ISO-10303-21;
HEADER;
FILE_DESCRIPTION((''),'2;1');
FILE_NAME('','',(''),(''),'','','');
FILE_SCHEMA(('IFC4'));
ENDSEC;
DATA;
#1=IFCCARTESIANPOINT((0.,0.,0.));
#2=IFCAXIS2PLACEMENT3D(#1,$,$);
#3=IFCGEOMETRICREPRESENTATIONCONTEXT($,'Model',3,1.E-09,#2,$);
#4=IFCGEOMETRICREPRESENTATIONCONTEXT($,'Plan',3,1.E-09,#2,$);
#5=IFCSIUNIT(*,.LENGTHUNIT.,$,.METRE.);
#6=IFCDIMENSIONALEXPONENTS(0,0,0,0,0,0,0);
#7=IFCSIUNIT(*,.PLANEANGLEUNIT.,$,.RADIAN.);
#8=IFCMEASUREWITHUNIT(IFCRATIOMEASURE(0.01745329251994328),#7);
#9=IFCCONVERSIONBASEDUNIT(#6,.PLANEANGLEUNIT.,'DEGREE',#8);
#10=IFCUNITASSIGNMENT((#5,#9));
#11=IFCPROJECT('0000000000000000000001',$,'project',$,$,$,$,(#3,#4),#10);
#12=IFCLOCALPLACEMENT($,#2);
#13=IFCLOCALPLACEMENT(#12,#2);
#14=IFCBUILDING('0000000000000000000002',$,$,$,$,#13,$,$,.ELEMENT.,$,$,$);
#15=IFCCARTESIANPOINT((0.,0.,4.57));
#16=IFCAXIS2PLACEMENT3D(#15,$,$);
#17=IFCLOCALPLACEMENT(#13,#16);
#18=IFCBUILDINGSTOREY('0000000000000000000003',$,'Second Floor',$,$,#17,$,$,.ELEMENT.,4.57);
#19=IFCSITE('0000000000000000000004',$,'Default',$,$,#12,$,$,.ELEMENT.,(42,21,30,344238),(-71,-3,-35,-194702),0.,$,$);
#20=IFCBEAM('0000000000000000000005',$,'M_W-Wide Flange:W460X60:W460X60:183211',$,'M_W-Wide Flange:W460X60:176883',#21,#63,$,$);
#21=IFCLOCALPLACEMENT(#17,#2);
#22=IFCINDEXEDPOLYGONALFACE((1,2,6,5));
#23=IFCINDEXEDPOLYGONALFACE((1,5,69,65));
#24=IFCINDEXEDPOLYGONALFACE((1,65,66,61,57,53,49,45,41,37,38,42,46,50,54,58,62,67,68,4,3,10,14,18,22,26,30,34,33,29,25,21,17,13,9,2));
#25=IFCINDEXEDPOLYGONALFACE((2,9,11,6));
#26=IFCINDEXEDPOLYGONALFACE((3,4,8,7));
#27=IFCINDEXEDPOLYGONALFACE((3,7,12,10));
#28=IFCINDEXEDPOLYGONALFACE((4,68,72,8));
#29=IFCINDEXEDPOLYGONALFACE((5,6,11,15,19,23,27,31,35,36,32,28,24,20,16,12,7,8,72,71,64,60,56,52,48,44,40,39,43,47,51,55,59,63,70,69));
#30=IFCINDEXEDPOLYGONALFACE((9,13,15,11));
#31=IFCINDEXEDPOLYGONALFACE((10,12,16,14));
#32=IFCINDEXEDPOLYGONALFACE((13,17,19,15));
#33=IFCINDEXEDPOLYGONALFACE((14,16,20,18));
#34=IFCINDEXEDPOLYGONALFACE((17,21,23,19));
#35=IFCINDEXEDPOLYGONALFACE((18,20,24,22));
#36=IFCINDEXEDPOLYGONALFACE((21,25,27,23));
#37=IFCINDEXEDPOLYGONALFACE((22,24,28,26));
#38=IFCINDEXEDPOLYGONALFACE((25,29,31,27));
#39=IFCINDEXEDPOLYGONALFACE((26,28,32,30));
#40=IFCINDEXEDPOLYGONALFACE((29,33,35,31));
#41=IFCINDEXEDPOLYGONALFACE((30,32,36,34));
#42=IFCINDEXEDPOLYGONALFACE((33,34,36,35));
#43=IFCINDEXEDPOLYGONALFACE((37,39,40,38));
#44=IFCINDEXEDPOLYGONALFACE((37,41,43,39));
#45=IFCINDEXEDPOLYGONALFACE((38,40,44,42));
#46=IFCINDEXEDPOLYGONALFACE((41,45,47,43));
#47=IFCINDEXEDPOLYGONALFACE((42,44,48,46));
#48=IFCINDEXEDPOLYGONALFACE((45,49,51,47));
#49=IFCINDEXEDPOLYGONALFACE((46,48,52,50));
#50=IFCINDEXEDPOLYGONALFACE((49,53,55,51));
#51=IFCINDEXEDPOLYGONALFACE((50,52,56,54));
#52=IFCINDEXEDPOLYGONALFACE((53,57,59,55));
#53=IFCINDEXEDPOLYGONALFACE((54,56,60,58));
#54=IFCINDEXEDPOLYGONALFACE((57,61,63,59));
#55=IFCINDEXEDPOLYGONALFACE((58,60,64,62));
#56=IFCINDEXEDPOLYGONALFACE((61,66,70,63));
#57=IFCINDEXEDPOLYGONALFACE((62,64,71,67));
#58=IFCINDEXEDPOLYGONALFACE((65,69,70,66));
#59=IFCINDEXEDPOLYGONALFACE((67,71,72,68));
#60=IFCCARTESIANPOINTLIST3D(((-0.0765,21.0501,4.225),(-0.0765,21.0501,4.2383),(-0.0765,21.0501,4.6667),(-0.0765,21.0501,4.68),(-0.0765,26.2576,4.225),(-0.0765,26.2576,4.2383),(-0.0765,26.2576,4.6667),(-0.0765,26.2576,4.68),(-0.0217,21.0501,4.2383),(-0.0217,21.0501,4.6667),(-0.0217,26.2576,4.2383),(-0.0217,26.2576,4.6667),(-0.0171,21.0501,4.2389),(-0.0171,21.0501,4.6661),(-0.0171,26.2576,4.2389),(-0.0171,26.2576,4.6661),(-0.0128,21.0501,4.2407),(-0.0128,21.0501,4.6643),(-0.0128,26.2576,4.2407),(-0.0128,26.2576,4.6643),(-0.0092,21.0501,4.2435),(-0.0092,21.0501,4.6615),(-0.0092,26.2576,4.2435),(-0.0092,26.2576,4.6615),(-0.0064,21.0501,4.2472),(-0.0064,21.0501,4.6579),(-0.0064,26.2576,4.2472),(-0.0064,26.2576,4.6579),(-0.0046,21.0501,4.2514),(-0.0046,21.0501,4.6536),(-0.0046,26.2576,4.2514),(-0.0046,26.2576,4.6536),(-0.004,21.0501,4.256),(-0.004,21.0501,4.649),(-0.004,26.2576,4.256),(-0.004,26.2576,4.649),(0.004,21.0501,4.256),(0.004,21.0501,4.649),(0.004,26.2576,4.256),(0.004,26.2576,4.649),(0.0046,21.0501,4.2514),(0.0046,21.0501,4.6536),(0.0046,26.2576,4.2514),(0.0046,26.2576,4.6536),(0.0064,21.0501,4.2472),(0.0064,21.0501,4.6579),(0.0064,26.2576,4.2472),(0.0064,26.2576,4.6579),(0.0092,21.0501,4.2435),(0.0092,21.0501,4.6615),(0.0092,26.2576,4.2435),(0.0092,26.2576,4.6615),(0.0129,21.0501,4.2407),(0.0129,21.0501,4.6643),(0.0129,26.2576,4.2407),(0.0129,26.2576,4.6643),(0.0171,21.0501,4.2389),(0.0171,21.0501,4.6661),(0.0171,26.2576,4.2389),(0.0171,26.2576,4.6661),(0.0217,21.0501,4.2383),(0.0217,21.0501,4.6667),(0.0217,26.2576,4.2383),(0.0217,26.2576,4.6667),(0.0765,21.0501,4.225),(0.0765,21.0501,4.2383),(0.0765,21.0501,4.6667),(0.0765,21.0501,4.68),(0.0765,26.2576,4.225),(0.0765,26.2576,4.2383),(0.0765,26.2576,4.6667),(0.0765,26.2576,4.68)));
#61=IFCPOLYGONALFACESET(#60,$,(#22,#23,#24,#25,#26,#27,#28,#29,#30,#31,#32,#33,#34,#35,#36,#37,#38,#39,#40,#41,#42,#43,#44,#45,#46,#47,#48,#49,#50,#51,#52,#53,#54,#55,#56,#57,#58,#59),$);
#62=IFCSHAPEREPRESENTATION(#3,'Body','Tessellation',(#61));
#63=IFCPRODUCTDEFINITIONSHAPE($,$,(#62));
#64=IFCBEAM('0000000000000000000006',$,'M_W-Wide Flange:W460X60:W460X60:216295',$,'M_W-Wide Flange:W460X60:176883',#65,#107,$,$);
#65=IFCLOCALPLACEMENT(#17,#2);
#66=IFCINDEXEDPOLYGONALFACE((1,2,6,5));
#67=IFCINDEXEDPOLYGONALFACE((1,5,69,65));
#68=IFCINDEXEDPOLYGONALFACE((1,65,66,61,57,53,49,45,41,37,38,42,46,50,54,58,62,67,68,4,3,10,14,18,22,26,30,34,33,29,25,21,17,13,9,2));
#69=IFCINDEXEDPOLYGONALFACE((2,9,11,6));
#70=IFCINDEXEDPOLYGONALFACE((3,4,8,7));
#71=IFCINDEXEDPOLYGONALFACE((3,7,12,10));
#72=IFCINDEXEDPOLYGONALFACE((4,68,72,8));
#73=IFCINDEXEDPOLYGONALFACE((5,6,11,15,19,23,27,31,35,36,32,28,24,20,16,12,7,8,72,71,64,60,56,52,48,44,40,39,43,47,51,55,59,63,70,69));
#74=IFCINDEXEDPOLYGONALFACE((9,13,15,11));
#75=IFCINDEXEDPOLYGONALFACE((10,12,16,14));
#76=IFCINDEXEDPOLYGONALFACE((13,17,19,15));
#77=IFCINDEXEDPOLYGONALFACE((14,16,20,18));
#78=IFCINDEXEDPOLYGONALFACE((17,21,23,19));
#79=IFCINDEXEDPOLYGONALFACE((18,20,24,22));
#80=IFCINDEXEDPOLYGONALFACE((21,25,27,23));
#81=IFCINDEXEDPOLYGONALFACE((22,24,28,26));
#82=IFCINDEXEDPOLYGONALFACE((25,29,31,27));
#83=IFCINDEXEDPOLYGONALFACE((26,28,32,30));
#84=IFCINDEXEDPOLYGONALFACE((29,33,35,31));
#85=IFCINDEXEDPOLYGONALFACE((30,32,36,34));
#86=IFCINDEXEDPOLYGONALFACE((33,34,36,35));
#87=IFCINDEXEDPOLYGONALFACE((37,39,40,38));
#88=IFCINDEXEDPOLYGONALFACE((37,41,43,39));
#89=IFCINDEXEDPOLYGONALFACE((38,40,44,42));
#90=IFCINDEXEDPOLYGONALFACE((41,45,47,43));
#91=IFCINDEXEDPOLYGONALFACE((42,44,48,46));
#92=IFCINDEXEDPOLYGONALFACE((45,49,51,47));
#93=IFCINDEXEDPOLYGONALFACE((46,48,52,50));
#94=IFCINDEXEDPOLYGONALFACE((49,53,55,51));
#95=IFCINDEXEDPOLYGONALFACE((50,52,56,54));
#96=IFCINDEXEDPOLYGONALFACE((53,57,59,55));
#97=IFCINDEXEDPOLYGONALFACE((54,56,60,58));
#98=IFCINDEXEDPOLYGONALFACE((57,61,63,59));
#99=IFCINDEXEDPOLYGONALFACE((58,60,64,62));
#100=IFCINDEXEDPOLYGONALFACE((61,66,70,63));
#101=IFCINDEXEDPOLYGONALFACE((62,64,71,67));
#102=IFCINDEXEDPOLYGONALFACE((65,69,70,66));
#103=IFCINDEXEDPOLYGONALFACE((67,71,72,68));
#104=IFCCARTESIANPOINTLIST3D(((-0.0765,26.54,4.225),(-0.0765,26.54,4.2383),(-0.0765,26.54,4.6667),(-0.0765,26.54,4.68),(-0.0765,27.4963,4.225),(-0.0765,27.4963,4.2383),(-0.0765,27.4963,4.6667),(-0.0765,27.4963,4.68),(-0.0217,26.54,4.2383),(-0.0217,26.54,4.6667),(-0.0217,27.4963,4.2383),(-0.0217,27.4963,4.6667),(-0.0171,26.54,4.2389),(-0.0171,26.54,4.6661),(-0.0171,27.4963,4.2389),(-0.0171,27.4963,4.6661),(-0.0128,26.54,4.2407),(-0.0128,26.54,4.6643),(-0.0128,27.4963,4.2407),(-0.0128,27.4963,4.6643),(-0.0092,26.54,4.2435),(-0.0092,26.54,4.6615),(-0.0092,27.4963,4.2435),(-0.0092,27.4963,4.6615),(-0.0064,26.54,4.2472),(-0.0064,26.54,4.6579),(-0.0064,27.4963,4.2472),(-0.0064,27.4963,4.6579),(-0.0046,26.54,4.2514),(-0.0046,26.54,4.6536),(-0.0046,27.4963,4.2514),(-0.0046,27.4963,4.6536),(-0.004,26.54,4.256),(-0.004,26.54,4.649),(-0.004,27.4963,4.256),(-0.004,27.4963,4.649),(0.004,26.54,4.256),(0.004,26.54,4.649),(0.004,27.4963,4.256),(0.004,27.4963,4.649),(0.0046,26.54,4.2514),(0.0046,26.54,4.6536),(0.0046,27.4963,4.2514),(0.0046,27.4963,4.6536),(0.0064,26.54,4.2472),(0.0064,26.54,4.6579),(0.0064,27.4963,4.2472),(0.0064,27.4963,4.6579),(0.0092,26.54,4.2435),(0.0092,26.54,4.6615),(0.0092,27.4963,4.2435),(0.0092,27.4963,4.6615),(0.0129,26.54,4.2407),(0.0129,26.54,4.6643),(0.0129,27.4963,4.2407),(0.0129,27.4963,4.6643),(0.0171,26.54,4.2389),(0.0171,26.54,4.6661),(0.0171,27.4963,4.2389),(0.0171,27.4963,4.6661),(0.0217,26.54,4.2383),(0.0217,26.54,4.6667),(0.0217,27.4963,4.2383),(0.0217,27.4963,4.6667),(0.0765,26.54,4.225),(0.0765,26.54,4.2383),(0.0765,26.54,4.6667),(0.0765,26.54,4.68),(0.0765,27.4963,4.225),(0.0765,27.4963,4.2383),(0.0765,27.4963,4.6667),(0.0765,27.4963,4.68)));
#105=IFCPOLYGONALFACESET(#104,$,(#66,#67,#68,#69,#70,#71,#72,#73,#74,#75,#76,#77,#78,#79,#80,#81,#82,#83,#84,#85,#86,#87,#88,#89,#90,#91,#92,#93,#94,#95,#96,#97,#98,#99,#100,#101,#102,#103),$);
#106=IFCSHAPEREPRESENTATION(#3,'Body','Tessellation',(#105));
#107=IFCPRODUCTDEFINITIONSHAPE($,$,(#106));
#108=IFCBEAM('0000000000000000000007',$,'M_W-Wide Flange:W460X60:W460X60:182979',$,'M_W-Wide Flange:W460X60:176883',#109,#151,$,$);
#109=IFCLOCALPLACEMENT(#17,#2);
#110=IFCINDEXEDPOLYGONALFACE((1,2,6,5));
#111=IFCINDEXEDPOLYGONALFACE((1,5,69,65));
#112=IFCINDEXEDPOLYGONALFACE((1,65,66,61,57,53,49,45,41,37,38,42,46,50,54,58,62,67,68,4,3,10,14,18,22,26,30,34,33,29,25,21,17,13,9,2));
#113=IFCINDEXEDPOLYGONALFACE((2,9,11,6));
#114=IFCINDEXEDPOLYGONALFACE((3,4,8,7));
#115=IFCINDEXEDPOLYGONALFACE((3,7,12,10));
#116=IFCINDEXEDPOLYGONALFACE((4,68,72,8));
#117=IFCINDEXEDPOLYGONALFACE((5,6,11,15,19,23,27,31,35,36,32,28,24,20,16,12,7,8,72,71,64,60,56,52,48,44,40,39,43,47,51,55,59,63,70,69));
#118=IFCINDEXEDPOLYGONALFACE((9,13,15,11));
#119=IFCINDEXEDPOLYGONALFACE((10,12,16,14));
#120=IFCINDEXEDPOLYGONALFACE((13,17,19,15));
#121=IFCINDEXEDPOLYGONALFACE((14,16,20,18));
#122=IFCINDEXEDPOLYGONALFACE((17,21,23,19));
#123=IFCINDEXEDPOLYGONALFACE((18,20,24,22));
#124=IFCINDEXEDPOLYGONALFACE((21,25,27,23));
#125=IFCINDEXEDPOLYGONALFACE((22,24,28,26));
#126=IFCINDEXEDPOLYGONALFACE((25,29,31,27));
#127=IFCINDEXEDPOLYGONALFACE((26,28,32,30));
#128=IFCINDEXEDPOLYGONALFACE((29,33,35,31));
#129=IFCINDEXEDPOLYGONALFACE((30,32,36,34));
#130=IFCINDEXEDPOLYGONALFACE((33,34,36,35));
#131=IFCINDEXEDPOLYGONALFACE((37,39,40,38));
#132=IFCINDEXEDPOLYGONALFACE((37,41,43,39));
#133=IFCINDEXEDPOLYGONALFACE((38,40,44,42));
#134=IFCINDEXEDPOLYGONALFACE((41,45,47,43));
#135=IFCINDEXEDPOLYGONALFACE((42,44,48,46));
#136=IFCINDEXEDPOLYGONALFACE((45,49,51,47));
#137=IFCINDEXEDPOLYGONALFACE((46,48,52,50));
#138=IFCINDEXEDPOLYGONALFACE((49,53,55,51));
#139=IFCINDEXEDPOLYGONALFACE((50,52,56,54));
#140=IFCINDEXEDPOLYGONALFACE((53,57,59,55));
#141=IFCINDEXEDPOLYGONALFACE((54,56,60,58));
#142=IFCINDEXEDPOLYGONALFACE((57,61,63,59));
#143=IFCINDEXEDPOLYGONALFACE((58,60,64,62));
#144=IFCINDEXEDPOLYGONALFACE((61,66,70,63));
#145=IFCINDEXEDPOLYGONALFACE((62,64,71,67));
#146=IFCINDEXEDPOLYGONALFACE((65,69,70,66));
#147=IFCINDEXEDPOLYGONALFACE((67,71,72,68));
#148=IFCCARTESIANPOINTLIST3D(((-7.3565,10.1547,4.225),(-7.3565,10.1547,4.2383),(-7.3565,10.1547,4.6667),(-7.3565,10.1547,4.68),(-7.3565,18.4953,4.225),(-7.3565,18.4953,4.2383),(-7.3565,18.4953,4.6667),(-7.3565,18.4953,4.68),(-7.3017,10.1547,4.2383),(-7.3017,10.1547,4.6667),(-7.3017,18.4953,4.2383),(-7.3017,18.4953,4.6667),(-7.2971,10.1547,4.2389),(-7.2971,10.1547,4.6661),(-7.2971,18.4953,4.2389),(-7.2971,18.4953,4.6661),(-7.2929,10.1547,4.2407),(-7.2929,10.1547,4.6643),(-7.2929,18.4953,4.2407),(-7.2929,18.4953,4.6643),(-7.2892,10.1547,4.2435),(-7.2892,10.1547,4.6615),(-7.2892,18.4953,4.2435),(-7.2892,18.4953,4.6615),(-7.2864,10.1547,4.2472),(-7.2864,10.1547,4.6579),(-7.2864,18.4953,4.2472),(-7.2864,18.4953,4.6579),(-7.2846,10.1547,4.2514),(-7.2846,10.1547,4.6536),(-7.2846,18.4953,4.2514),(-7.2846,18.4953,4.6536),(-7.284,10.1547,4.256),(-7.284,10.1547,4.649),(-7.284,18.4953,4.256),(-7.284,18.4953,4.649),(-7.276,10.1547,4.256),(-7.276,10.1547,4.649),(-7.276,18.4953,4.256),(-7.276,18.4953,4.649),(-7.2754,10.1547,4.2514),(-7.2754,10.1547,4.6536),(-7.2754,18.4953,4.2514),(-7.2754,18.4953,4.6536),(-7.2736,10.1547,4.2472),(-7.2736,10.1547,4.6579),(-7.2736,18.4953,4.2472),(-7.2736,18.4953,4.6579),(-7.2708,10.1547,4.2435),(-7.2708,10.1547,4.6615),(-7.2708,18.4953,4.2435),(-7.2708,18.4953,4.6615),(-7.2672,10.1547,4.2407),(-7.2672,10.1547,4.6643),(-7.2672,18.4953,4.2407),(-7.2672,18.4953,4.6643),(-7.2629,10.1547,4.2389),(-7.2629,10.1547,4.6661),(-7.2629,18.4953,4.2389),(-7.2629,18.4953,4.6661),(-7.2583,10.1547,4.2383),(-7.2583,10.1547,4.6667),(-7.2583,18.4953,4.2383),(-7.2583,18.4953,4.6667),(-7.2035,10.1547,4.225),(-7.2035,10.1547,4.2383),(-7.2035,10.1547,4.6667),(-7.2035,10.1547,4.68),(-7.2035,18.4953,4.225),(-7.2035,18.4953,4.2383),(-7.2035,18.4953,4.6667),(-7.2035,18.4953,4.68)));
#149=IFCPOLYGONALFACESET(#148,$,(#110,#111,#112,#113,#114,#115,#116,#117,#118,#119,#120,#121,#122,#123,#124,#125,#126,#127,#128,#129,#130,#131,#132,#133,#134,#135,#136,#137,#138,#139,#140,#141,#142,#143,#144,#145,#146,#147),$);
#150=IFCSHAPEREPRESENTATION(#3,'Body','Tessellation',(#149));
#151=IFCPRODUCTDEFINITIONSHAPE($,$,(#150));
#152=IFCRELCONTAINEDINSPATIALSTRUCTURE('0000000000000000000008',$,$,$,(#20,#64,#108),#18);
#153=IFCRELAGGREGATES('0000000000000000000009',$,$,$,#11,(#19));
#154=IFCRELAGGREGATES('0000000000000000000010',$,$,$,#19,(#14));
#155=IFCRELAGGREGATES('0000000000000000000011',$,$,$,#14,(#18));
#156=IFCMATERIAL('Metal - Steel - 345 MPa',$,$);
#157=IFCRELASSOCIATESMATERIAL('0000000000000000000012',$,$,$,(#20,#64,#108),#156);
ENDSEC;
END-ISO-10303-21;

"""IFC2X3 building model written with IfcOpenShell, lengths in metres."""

from ifc_helpers import new_model, entity, si_unit, converted_unit, frame, frame_2d, origin, place, context, project, spatial, polyline, circle_curve, parameter, trimmed, segment, composite_curve, outline, extrude, material, element, save


model = new_model("IFC2X3")

# Units and contexts
model_context = context("Model", 3, precision=1e-09, world=origin())
plan_context = context("Plan", 3, precision=1e-09, world=origin())
ifc_project = project(units=[si_unit("LENGTHUNIT", "METRE"), converted_unit("PLANEANGLEUNIT", "DEGREE", entity("IfcRatioMeasure", 0.01745329251994328), si_unit("PLANEANGLEUNIT", "RADIAN"), dimensions=[0, 0, 0, 0, 0, 0, 0])], contexts=[model_context, plan_context])

# Site, building, storey
site_placement = place(None, origin())
site = spatial("IfcSite", under=ifc_project, at=site_placement, Name="Default", CompositionType="ELEMENT", RefLatitude=(42, 21, 30, 344238), RefLongitude=(-71, -3, -35, -194702), RefElevation=0.0)
building_placement = place(site_placement, origin())
building = spatial("IfcBuilding", under=site, at=building_placement, CompositionType="ELEMENT")
storey_placement = place(building_placement, frame((0.0, 0.0, 4.57)))
storey = spatial("IfcBuildingStorey", under=building, at=storey_placement, Name="Second Floor", CompositionType="ELEMENT", Elevation=4.57)

# Shared definitions
ifc_material = material(Name="Metal - Steel - 345 MPa")

# Beams
beam_1_placement = place(storey_placement, frame((0.0, 26.4232, 4.68), z_axis=(0.0, 0.0, 1.0), x_axis=(-1.0, 0.0, 0.0)))
element("IfcBeam", 1, at=beam_1_placement, inside=storey, material=ifc_material, Name="M_W-Wide Flange:W460X60:W460X60:183211", ObjectType="M_W-Wide Flange:W460X60:176883", context=model_context, shape_type="SweptSolid", body=[
    extrude(outline(composite_curve([segment(polyline([(0.2142, -0.0765), (0.2275, -0.0765)]), True, "CONTINUOUS"), segment(polyline([(0.2275, -0.0765), (0.2275, 0.0765)]), True, "CONTINUOUS"), segment(polyline([(0.2275, 0.0765), (0.2142, 0.0765)]), True, "CONTINUOUS"), segment(polyline([(0.2142, 0.0765), (0.2142, 0.0217)]), True, "CONTINUOUS"), segment(trimmed(circle_curve(frame_2d((0.1965, 0.0217), x_axis=(0.0, 1.0)), 0.0177), [parameter(180.0)], [parameter(270.0)], True, "PARAMETER"), False, "CONTINUOUS"), segment(polyline([(0.1965, 0.004), (-0.1965, 0.004)]), True, "CONTINUOUS"), segment(trimmed(circle_curve(frame_2d((-0.1965, 0.0217), x_axis=(0.0, 1.0)), 0.0177), [parameter(90.0)], [parameter(180.0)], True, "PARAMETER"), False, "CONTINUOUS"), segment(polyline([(-0.2142, 0.0217), (-0.2142, 0.0765)]), True, "CONTINUOUS"), segment(polyline([(-0.2142, 0.0765), (-0.2275, 0.0765)]), True, "CONTINUOUS"), segment(polyline([(-0.2275, 0.0765), (-0.2275, -0.0765)]), True, "CONTINUOUS"), segment(polyline([(-0.2275, -0.0765), (-0.2142, -0.0765)]), True, "CONTINUOUS"), segment(polyline([(-0.2142, -0.0765), (-0.2142, -0.0217)]), True, "CONTINUOUS"), segment(trimmed(circle_curve(frame_2d((-0.1965, -0.0217), x_axis=(0.0, 1.0)), 0.0177), [parameter(360.0)], [parameter(90.0)], True, "PARAMETER"), False, "CONTINUOUS"), segment(polyline([(-0.1965, -0.004), (0.1965, -0.004)]), True, "CONTINUOUS"), segment(trimmed(circle_curve(frame_2d((0.1965, -0.0217), x_axis=(0.0, 1.0)), 0.0177), [parameter(270.0)], [parameter(0.0)], True, "PARAMETER"), False, "CONTINUOUS"), segment(polyline([(0.2142, -0.0217), (0.2142, -0.0765)]), True, "CONTINUOUS")], self_intersect=False)), frame((0.0, 5.3731, -0.2275), z_axis=(0.0, -1.0, 0.0), x_axis=(0.0, 0.0, -1.0)), (0.0, 0.0, 1.0), 5.2075),
])
beam_2_placement = place(storey_placement, frame((0.0, 26.41, 4.68)))
element("IfcBeam", 2, at=beam_2_placement, inside=storey, material=ifc_material, Name="M_W-Wide Flange:W460X60:W460X60:216295", ObjectType="M_W-Wide Flange:W460X60:176883", context=model_context, shape_type="SweptSolid", body=[
    extrude(outline(composite_curve([segment(polyline([(0.2142, -0.0765), (0.2275, -0.0765)]), True, "CONTINUOUS"), segment(polyline([(0.2275, -0.0765), (0.2275, 0.0765)]), True, "CONTINUOUS"), segment(polyline([(0.2275, 0.0765), (0.2142, 0.0765)]), True, "CONTINUOUS"), segment(polyline([(0.2142, 0.0765), (0.2142, 0.0217)]), True, "CONTINUOUS"), segment(trimmed(circle_curve(frame_2d((0.1965, 0.0217), x_axis=(0.0, 1.0)), 0.0177), [parameter(180.0)], [parameter(270.0)], True, "PARAMETER"), False, "CONTINUOUS"), segment(polyline([(0.1965, 0.004), (-0.1965, 0.004)]), True, "CONTINUOUS"), segment(trimmed(circle_curve(frame_2d((-0.1965, 0.0217), x_axis=(0.0, 1.0)), 0.0177), [parameter(90.0)], [parameter(180.0)], True, "PARAMETER"), False, "CONTINUOUS"), segment(polyline([(-0.2142, 0.0217), (-0.2142, 0.0765)]), True, "CONTINUOUS"), segment(polyline([(-0.2142, 0.0765), (-0.2275, 0.0765)]), True, "CONTINUOUS"), segment(polyline([(-0.2275, 0.0765), (-0.2275, -0.0765)]), True, "CONTINUOUS"), segment(polyline([(-0.2275, -0.0765), (-0.2142, -0.0765)]), True, "CONTINUOUS"), segment(polyline([(-0.2142, -0.0765), (-0.2142, -0.0217)]), True, "CONTINUOUS"), segment(trimmed(circle_curve(frame_2d((-0.1965, -0.0217), x_axis=(0.0, 1.0)), 0.0177), [parameter(360.0)], [parameter(90.0)], True, "PARAMETER"), False, "CONTINUOUS"), segment(polyline([(-0.1965, -0.004), (0.1965, -0.004)]), True, "CONTINUOUS"), segment(trimmed(circle_curve(frame_2d((0.1965, -0.0217), x_axis=(0.0, 1.0)), 0.0177), [parameter(270.0)], [parameter(0.0)], True, "PARAMETER"), False, "CONTINUOUS"), segment(polyline([(0.2142, -0.0217), (0.2142, -0.0765)]), True, "CONTINUOUS")], self_intersect=False)), frame((0.0, 0.13, -0.2275), z_axis=(0.0, 1.0, 0.0), x_axis=(0.0, 0.0, -1.0)), (0.0, 0.0, 1.0), 0.9563),
])
beam_3_placement = place(storey_placement, frame((-7.28, 10.0422, 4.68)))
element("IfcBeam", 3, at=beam_3_placement, inside=storey, material=ifc_material, Name="M_W-Wide Flange:W460X60:W460X60:182979", ObjectType="M_W-Wide Flange:W460X60:176883", context=model_context, shape_type="SweptSolid", body=[
    extrude(outline(composite_curve([segment(polyline([(-0.0765, -0.2142), (-0.0765, -0.2275)]), True, "CONTINUOUS"), segment(polyline([(-0.0765, -0.2275), (0.0765, -0.2275)]), True, "CONTINUOUS"), segment(polyline([(0.0765, -0.2275), (0.0765, -0.2142)]), True, "CONTINUOUS"), segment(polyline([(0.0765, -0.2142), (0.0217, -0.2142)]), True, "CONTINUOUS"), segment(trimmed(circle_curve(frame_2d((0.0217, -0.1965), x_axis=(0.0, -1.0)), 0.0177), [parameter(270.0)], [parameter(360.0)], True, "PARAMETER"), False, "CONTINUOUS"), segment(polyline([(0.004, -0.1965), (0.004, 0.1965)]), True, "CONTINUOUS"), segment(trimmed(circle_curve(frame_2d((0.0217, 0.1965), x_axis=(-1.0, 0.0)), 0.0177), [parameter(270.0)], [parameter(360.0)], True, "PARAMETER"), False, "CONTINUOUS"), segment(polyline([(0.0217, 0.2142), (0.0765, 0.2142)]), True, "CONTINUOUS"), segment(polyline([(0.0765, 0.2142), (0.0765, 0.2275)]), True, "CONTINUOUS"), segment(polyline([(0.0765, 0.2275), (-0.0765, 0.2275)]), True, "CONTINUOUS"), segment(polyline([(-0.0765, 0.2275), (-0.0765, 0.2142)]), True, "CONTINUOUS"), segment(polyline([(-0.0765, 0.2142), (-0.0217, 0.2142)]), True, "CONTINUOUS"), segment(trimmed(circle_curve(frame_2d((-0.0217, 0.1965), x_axis=(0.0, 1.0)), 0.0177), [parameter(270.0)], [parameter(360.0)], True, "PARAMETER"), False, "CONTINUOUS"), segment(polyline([(-0.004, 0.1965), (-0.004, -0.1965)]), True, "CONTINUOUS"), segment(trimmed(circle_curve(frame_2d((-0.0217, -0.1965), x_axis=(1.0, 0.0)), 0.0177), [parameter(270.0)], [parameter(0.0)], True, "PARAMETER"), False, "CONTINUOUS"), segment(polyline([(-0.0217, -0.2142), (-0.0765, -0.2142)]), True, "CONTINUOUS")], self_intersect=False)), frame((0.0, 0.1125, -0.2275), z_axis=(0.0, -1.0, 0.0), x_axis=(1.0, 0.0, 0.0)), (0.0, 0.0, -1.0), 8.3406),
])

save(model, "model.ifc")
